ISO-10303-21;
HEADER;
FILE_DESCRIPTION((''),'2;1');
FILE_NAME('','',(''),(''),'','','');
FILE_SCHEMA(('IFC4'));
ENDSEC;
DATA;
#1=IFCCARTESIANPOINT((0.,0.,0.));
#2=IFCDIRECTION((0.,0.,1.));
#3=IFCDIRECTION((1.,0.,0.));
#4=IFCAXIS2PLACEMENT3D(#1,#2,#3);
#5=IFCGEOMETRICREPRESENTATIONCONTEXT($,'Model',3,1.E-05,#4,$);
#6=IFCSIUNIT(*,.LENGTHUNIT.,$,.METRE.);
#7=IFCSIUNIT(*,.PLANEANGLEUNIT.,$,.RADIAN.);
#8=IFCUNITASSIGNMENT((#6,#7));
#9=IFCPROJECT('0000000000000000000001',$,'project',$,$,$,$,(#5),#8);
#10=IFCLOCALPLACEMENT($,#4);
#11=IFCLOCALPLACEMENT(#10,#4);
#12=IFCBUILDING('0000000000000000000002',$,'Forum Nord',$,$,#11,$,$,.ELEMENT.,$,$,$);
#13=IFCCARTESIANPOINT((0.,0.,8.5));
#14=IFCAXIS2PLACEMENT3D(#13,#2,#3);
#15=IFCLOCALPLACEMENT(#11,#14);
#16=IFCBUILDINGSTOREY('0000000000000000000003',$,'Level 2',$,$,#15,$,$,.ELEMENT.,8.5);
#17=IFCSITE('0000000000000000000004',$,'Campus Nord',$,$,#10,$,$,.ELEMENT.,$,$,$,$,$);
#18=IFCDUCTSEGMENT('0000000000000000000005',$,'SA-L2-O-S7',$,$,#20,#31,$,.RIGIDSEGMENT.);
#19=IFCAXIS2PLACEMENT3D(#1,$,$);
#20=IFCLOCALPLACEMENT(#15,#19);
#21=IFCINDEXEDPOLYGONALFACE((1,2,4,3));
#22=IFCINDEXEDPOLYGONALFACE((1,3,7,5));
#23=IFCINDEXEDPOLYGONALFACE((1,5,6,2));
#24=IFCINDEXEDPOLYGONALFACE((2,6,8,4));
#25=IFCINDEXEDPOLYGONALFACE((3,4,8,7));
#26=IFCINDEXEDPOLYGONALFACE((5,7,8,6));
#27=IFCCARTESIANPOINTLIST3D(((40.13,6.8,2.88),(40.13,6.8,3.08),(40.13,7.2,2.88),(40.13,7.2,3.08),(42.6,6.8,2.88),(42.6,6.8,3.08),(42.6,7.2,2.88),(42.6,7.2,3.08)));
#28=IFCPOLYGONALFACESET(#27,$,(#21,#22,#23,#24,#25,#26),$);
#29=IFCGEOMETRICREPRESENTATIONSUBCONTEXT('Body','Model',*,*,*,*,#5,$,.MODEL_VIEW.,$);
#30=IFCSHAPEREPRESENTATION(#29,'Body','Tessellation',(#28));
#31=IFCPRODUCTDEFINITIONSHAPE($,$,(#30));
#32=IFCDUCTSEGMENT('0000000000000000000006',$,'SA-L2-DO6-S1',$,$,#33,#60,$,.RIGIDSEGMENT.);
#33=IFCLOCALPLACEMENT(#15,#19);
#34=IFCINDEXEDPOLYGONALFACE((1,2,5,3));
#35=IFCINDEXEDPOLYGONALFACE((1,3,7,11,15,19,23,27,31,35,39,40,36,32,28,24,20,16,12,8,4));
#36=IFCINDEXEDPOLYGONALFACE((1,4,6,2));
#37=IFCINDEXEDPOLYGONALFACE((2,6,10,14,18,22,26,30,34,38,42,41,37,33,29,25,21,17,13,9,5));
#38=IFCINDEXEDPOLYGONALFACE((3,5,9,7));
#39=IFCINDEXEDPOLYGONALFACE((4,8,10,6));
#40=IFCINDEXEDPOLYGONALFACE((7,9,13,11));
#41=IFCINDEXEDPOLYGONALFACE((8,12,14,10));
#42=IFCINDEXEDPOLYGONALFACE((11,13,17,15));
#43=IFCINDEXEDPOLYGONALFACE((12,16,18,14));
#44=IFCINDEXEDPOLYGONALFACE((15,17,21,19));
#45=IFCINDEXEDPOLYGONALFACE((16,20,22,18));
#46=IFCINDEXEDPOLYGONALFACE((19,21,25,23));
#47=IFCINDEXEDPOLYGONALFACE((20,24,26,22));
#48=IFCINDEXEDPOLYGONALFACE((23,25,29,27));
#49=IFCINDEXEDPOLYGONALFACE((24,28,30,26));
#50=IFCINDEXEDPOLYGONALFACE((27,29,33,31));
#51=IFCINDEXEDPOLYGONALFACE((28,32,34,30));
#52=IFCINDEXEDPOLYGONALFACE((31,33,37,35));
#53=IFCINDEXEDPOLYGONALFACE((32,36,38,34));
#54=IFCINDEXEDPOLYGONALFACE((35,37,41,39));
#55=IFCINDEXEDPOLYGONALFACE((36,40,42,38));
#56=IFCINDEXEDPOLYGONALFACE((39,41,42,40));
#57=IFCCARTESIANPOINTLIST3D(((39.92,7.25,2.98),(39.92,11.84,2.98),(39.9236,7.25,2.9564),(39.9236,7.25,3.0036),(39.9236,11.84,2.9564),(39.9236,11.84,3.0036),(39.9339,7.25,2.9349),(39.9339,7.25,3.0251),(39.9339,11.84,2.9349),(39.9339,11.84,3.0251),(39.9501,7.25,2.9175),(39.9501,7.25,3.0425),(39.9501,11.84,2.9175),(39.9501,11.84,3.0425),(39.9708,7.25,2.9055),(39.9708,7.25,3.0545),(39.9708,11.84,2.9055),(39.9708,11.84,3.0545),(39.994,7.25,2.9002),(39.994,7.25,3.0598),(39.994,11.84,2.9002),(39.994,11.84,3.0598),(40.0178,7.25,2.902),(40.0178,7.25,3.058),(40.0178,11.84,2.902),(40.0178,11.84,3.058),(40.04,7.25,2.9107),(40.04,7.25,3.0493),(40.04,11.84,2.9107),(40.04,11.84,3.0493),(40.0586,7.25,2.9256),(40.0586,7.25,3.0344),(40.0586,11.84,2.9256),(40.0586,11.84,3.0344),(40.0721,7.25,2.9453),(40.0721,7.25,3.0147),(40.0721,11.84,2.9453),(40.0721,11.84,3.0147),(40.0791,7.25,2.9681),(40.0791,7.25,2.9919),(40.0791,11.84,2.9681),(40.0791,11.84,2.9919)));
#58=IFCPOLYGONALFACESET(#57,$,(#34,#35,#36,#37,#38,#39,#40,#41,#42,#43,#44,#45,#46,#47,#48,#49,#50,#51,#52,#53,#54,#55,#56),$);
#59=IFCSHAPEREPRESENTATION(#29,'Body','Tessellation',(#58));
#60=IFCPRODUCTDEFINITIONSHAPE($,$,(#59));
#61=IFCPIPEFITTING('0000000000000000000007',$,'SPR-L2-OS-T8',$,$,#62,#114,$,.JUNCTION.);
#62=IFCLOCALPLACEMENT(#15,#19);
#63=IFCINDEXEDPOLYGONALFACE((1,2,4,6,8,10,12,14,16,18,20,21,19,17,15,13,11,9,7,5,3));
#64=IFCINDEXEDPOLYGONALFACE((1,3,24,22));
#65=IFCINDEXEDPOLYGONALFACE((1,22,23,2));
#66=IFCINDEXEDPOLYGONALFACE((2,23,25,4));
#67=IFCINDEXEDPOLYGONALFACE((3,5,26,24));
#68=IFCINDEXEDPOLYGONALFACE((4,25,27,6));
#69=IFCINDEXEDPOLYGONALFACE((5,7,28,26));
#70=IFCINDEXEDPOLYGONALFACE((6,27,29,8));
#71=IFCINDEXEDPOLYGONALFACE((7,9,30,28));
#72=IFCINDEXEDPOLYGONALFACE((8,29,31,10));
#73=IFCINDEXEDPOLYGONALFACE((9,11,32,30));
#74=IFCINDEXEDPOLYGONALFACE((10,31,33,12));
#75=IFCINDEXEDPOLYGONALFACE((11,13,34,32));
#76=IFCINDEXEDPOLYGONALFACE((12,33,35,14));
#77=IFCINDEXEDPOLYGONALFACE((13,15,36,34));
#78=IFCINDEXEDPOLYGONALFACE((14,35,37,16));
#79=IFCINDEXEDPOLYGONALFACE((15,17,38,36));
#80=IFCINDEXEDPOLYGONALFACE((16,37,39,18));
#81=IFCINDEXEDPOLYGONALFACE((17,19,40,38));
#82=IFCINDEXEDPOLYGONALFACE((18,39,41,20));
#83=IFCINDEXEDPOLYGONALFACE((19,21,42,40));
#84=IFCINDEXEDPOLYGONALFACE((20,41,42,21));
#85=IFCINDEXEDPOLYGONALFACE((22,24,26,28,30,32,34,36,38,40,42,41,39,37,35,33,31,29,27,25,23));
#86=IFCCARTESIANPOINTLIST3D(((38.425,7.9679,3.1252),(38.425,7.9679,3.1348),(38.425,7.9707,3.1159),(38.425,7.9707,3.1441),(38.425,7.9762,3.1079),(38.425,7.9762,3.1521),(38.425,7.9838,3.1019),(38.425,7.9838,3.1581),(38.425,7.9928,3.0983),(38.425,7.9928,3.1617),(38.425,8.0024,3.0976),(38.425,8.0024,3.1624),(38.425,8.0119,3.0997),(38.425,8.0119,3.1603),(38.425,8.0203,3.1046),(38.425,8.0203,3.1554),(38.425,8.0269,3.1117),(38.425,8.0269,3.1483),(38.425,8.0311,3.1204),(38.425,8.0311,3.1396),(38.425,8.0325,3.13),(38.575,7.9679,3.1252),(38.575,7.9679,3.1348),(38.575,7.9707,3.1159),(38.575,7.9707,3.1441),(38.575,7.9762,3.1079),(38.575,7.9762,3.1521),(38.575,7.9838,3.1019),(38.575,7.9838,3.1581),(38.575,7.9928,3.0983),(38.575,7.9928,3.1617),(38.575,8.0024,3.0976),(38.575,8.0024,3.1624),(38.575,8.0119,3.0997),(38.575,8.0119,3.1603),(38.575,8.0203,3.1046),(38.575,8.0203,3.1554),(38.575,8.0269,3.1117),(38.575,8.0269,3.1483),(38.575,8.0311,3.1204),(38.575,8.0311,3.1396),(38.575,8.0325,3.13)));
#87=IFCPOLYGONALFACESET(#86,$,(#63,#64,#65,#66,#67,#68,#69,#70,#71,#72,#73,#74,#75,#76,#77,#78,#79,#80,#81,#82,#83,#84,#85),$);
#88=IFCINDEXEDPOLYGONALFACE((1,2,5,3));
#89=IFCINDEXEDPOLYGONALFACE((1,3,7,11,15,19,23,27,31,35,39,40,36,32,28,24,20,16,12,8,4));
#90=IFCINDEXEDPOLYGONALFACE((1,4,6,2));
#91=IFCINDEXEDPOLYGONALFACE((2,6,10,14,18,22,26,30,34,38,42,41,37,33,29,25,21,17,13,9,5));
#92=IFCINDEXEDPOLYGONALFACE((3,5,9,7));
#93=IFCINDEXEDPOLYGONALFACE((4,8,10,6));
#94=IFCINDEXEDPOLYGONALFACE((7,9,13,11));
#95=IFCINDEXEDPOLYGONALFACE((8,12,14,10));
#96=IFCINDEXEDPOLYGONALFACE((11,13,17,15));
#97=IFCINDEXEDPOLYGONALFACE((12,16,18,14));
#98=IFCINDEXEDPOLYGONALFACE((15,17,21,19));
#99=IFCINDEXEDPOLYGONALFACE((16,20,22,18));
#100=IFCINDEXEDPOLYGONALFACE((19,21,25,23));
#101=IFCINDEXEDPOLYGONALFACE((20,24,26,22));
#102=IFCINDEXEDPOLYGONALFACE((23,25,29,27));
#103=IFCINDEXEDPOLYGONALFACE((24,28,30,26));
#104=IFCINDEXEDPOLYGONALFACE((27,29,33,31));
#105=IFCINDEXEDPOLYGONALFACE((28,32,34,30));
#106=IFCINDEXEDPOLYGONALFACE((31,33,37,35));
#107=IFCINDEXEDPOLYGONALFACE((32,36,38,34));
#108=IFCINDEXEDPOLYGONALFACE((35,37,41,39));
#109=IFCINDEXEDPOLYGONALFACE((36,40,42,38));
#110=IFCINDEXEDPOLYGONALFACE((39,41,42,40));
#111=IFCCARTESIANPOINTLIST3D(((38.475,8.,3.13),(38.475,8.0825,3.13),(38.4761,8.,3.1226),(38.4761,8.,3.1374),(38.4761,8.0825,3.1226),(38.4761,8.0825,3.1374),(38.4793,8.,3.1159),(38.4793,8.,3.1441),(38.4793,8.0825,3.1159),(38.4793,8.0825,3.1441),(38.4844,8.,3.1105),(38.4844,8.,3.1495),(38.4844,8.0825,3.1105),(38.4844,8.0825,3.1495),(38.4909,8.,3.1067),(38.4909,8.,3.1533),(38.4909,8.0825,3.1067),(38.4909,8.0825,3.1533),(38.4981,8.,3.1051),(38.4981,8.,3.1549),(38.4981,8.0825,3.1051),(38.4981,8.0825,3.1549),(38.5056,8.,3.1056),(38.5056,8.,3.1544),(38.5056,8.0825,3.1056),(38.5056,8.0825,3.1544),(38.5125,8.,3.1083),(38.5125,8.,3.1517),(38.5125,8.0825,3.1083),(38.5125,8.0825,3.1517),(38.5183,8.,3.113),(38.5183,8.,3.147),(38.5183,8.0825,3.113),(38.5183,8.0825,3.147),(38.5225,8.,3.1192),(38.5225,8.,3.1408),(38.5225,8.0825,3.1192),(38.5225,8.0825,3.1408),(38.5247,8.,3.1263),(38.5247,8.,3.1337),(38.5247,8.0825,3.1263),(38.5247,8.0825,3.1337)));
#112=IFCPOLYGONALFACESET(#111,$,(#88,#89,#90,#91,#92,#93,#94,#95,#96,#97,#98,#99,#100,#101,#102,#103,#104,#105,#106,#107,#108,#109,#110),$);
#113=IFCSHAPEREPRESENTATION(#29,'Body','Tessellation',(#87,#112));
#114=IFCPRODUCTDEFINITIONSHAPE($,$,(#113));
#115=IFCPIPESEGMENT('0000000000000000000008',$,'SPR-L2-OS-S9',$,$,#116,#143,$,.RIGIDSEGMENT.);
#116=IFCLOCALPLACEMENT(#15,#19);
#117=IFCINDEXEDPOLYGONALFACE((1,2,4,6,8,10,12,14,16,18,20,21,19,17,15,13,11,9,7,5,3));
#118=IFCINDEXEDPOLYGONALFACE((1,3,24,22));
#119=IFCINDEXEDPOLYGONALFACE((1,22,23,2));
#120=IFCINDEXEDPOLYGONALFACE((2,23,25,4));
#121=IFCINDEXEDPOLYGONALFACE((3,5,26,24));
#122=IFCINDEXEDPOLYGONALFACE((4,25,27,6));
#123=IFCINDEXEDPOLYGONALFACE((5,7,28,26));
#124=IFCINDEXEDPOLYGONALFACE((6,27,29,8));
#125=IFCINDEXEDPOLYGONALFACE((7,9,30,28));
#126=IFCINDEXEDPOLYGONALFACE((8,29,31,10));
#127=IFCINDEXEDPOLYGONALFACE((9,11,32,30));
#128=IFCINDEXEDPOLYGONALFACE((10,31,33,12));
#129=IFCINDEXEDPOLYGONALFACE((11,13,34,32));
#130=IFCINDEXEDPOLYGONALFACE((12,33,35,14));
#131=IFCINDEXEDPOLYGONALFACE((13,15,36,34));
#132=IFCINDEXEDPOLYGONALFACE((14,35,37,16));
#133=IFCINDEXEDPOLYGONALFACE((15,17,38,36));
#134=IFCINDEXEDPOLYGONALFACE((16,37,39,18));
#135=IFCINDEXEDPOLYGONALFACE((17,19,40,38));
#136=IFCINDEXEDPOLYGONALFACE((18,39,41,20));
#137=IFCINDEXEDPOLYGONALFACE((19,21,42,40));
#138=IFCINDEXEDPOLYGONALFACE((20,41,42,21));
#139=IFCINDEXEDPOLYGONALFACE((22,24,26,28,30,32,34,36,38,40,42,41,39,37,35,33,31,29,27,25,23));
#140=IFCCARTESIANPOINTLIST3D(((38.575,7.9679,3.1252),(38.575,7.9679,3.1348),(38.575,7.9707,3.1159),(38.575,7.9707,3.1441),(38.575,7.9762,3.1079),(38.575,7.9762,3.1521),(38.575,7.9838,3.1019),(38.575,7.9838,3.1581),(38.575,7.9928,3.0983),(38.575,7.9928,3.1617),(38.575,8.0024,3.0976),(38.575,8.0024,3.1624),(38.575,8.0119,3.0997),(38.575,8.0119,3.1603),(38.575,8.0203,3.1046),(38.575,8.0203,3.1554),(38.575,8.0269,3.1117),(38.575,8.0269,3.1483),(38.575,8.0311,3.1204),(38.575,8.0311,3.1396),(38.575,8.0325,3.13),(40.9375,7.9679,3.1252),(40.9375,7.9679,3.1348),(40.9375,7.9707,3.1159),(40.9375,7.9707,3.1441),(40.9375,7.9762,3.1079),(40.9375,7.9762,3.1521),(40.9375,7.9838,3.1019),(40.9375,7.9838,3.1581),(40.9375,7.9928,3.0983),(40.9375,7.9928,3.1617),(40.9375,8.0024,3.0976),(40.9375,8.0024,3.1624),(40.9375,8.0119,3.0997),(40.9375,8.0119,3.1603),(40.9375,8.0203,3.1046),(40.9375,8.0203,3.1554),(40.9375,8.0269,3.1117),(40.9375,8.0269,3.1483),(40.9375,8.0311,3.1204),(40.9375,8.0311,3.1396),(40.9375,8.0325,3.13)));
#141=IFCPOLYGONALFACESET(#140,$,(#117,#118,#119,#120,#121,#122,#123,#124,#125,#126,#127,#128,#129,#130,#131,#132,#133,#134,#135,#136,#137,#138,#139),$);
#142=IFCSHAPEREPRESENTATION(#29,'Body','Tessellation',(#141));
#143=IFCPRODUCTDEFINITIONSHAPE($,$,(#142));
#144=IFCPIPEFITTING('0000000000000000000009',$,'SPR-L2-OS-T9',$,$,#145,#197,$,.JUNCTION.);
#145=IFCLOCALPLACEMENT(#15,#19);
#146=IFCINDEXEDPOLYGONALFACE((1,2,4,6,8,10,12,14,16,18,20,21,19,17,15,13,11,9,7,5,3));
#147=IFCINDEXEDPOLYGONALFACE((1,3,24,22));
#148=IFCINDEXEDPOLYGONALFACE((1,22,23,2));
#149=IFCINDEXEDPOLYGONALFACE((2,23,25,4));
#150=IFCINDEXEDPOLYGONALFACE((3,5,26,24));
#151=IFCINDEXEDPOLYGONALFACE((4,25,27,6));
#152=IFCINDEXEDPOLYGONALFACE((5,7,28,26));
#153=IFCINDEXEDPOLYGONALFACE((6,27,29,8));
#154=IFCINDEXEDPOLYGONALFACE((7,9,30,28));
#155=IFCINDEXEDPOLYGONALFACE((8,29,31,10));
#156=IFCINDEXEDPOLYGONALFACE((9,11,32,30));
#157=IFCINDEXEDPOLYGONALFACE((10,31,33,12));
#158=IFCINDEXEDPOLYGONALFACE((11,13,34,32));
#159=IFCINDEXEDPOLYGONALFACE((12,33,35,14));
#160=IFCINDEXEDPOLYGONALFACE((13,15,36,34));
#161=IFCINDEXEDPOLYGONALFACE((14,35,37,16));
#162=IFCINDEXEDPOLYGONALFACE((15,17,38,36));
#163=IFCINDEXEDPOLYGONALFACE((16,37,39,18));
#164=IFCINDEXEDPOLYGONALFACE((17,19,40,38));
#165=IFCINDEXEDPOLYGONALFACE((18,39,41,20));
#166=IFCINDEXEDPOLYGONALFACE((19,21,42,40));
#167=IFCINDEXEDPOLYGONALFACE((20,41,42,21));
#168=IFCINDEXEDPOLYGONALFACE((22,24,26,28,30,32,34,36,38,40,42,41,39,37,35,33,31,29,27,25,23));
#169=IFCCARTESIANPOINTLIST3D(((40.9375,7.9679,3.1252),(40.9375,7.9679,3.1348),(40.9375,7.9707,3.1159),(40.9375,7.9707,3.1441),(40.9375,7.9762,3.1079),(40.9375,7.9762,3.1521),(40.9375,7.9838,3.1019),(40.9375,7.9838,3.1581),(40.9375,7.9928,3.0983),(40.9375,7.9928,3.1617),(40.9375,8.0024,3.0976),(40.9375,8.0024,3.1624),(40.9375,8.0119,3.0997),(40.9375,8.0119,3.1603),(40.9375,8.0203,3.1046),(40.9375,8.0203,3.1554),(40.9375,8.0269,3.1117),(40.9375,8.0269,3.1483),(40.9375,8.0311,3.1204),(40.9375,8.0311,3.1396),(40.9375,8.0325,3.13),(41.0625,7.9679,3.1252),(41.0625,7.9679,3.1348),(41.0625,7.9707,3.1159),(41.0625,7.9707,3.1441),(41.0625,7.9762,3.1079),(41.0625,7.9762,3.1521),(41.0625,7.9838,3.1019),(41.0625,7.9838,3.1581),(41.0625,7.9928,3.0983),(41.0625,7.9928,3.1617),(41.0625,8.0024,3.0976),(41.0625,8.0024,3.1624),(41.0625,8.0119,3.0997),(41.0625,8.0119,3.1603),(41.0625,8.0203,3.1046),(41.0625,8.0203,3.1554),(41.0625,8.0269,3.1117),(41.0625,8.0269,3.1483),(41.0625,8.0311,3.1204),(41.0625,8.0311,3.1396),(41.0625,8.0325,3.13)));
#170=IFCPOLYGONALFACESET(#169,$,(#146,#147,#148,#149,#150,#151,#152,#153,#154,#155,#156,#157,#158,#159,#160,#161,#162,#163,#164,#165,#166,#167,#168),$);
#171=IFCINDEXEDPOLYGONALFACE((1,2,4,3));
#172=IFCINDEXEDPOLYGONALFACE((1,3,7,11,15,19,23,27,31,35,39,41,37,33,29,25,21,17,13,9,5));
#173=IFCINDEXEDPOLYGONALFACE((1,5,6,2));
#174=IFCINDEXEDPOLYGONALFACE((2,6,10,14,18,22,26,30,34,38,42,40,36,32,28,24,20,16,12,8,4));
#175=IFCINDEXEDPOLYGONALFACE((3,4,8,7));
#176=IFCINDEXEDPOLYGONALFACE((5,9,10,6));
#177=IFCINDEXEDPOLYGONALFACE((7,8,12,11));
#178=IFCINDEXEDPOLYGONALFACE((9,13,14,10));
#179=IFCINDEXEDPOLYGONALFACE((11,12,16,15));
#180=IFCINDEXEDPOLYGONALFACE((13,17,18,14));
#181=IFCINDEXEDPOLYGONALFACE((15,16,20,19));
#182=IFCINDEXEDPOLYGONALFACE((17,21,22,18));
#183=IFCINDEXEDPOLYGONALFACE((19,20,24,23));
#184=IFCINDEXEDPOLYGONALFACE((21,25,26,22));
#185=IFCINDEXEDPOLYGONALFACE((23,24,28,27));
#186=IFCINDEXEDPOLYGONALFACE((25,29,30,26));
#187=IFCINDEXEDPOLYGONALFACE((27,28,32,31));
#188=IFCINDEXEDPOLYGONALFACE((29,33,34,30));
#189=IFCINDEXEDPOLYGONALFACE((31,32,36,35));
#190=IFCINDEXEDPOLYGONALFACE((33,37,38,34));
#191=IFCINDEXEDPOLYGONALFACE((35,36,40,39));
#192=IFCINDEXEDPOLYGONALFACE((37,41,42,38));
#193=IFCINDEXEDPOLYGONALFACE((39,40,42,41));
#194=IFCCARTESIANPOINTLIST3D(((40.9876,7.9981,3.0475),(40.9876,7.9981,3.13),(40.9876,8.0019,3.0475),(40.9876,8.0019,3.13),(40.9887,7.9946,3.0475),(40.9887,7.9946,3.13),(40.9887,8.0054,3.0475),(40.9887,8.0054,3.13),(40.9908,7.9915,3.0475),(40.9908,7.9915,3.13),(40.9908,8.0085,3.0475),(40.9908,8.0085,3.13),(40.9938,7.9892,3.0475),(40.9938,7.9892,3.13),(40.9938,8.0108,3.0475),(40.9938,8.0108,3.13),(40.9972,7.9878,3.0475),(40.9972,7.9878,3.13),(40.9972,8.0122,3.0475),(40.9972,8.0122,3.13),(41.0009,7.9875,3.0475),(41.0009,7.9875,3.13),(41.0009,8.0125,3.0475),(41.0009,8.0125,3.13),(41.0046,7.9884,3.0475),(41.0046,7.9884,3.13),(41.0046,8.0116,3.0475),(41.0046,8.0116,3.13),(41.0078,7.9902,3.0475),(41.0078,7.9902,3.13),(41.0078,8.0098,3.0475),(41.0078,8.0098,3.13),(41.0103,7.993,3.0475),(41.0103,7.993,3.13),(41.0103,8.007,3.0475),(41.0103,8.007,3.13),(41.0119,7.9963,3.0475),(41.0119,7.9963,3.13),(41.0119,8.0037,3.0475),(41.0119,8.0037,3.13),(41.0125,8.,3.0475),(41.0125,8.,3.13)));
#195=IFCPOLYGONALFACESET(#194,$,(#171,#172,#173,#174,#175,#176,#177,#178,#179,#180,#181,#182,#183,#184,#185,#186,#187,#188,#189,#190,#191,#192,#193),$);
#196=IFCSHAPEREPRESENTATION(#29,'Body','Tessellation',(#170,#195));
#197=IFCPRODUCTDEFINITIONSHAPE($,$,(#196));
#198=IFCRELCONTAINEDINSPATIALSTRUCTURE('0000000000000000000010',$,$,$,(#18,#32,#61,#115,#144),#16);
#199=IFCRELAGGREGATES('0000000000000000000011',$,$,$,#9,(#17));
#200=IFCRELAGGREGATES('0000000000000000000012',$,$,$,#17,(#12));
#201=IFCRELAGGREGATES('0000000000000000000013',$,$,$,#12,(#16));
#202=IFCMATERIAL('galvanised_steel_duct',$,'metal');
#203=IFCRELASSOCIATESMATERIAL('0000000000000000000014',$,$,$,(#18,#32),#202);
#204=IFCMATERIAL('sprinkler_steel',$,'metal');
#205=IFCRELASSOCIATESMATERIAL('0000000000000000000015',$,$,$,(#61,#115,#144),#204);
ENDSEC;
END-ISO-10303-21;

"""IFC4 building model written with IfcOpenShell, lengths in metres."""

from ifc_helpers import new_model, si_unit, frame, origin_with_axes, origin_2d_with_axis, place, context, subcontext, project, spatial, rectangle, circle, extrude, material, element, save


model = new_model("IFC4")

# Units and contexts
model_context = context("Model", 3, precision=1e-05, world=origin_with_axes())
body_context = subcontext(model_context, "Body", "Model", "MODEL_VIEW")
ifc_project = project(units=[si_unit("LENGTHUNIT", "METRE"), si_unit("PLANEANGLEUNIT", "RADIAN")], contexts=[model_context])

# Site, building, storey
site_placement = place(None, origin_with_axes())
site = spatial("IfcSite", under=ifc_project, at=site_placement, Name="Campus Nord", CompositionType="ELEMENT")
building_placement = place(site_placement, origin_with_axes())
building = spatial("IfcBuilding", under=site, at=building_placement, Name="Forum Nord", CompositionType="ELEMENT")
storey_placement = place(building_placement, frame((0.0, 0.0, 8.5), z_axis=(0.0, 0.0, 1.0), x_axis=(1.0, 0.0, 0.0)))
storey = spatial("IfcBuildingStorey", under=building, at=storey_placement, Name="Level 2", CompositionType="ELEMENT", Elevation=8.5)

# Duct segments
ifc_material_1 = material(Name="galvanised_steel_duct", Category="metal")
duct_segment_1_placement = place(storey_placement, frame((40.13, 7.0, 2.98), z_axis=(1.0, 0.0, 0.0), x_axis=(0.0, 1.0, 0.0)))
element("IfcDuctSegment", 1, at=duct_segment_1_placement, inside=storey, material=ifc_material_1, Name="SA-L2-O-S7", PredefinedType="RIGIDSEGMENT", context=body_context, shape_type="SweptSolid", body=[
    extrude(rectangle(XDim=0.4, YDim=0.2, at=origin_2d_with_axis()), origin_with_axes(), (0.0, 0.0, 1.0), 2.47),
])
duct_segment_2_placement = place(storey_placement, frame((40.0, 7.25, 2.98), z_axis=(0.0, 1.0, 0.0), x_axis=(-1.0, 0.0, 0.0)))
element("IfcDuctSegment", 2, at=duct_segment_2_placement, inside=storey, material=ifc_material_1, Name="SA-L2-DO6-S1", PredefinedType="RIGIDSEGMENT", context=body_context, shape_type="SweptSolid", body=[
    extrude(circle(Radius=0.08, at=origin_2d_with_axis()), origin_with_axes(), (0.0, 0.0, 1.0), 4.59),
])

# Pipe fitting
ifc_material_2 = material(Name="sprinkler_steel", Category="metal")
pipe_fitting_1_placement = place(storey_placement, frame((38.425, 8.0, 3.13), z_axis=(1.0, 0.0, 0.0), x_axis=(0.0, 1.0, 0.0)))
element("IfcPipeFitting", 3, at=pipe_fitting_1_placement, inside=storey, material=ifc_material_2, Name="SPR-L2-OS-T8", PredefinedType="JUNCTION", context=body_context, shape_type="SweptSolid", body=[
    extrude(circle(Radius=0.0325, at=origin_2d_with_axis()), origin_with_axes(), (0.0, 0.0, 1.0), 0.15),
    extrude(circle(Radius=0.025, at=origin_2d_with_axis()), frame((0.0, 0.0, 0.075), z_axis=(1.0, 0.0, 0.0), x_axis=(0.0, 0.0, -1.0)), (0.0, 0.0, 1.0), 0.0825),
])

# Pipe segment
pipe_segment_1_placement = place(storey_placement, frame((38.575, 8.0, 3.13), z_axis=(1.0, 0.0, 0.0), x_axis=(0.0, 1.0, 0.0)))
element("IfcPipeSegment", 4, at=pipe_segment_1_placement, inside=storey, material=ifc_material_2, Name="SPR-L2-OS-S9", PredefinedType="RIGIDSEGMENT", context=body_context, shape_type="SweptSolid", body=[
    extrude(circle(Radius=0.0325, at=origin_2d_with_axis()), origin_with_axes(), (0.0, 0.0, 1.0), 2.3625),
])

# Pipe fitting
pipe_fitting_2_placement = place(storey_placement, frame((40.9375, 8.0, 3.13), z_axis=(1.0, 0.0, 0.0), x_axis=(0.0, 1.0, 0.0)))
element("IfcPipeFitting", 5, at=pipe_fitting_2_placement, inside=storey, material=ifc_material_2, Name="SPR-L2-OS-T9", PredefinedType="JUNCTION", context=body_context, shape_type="SweptSolid", body=[
    extrude(circle(Radius=0.0325, at=origin_2d_with_axis()), origin_with_axes(), (0.0, 0.0, 1.0), 0.125),
    extrude(circle(Radius=0.0125, at=origin_2d_with_axis()), frame((0.0, 0.0, 0.0625), z_axis=(0.0, -1.0, 0.0), x_axis=(0.0, 0.0, 1.0)), (0.0, 0.0, 1.0), 0.0825),
])

save(model, "model.ifc")
